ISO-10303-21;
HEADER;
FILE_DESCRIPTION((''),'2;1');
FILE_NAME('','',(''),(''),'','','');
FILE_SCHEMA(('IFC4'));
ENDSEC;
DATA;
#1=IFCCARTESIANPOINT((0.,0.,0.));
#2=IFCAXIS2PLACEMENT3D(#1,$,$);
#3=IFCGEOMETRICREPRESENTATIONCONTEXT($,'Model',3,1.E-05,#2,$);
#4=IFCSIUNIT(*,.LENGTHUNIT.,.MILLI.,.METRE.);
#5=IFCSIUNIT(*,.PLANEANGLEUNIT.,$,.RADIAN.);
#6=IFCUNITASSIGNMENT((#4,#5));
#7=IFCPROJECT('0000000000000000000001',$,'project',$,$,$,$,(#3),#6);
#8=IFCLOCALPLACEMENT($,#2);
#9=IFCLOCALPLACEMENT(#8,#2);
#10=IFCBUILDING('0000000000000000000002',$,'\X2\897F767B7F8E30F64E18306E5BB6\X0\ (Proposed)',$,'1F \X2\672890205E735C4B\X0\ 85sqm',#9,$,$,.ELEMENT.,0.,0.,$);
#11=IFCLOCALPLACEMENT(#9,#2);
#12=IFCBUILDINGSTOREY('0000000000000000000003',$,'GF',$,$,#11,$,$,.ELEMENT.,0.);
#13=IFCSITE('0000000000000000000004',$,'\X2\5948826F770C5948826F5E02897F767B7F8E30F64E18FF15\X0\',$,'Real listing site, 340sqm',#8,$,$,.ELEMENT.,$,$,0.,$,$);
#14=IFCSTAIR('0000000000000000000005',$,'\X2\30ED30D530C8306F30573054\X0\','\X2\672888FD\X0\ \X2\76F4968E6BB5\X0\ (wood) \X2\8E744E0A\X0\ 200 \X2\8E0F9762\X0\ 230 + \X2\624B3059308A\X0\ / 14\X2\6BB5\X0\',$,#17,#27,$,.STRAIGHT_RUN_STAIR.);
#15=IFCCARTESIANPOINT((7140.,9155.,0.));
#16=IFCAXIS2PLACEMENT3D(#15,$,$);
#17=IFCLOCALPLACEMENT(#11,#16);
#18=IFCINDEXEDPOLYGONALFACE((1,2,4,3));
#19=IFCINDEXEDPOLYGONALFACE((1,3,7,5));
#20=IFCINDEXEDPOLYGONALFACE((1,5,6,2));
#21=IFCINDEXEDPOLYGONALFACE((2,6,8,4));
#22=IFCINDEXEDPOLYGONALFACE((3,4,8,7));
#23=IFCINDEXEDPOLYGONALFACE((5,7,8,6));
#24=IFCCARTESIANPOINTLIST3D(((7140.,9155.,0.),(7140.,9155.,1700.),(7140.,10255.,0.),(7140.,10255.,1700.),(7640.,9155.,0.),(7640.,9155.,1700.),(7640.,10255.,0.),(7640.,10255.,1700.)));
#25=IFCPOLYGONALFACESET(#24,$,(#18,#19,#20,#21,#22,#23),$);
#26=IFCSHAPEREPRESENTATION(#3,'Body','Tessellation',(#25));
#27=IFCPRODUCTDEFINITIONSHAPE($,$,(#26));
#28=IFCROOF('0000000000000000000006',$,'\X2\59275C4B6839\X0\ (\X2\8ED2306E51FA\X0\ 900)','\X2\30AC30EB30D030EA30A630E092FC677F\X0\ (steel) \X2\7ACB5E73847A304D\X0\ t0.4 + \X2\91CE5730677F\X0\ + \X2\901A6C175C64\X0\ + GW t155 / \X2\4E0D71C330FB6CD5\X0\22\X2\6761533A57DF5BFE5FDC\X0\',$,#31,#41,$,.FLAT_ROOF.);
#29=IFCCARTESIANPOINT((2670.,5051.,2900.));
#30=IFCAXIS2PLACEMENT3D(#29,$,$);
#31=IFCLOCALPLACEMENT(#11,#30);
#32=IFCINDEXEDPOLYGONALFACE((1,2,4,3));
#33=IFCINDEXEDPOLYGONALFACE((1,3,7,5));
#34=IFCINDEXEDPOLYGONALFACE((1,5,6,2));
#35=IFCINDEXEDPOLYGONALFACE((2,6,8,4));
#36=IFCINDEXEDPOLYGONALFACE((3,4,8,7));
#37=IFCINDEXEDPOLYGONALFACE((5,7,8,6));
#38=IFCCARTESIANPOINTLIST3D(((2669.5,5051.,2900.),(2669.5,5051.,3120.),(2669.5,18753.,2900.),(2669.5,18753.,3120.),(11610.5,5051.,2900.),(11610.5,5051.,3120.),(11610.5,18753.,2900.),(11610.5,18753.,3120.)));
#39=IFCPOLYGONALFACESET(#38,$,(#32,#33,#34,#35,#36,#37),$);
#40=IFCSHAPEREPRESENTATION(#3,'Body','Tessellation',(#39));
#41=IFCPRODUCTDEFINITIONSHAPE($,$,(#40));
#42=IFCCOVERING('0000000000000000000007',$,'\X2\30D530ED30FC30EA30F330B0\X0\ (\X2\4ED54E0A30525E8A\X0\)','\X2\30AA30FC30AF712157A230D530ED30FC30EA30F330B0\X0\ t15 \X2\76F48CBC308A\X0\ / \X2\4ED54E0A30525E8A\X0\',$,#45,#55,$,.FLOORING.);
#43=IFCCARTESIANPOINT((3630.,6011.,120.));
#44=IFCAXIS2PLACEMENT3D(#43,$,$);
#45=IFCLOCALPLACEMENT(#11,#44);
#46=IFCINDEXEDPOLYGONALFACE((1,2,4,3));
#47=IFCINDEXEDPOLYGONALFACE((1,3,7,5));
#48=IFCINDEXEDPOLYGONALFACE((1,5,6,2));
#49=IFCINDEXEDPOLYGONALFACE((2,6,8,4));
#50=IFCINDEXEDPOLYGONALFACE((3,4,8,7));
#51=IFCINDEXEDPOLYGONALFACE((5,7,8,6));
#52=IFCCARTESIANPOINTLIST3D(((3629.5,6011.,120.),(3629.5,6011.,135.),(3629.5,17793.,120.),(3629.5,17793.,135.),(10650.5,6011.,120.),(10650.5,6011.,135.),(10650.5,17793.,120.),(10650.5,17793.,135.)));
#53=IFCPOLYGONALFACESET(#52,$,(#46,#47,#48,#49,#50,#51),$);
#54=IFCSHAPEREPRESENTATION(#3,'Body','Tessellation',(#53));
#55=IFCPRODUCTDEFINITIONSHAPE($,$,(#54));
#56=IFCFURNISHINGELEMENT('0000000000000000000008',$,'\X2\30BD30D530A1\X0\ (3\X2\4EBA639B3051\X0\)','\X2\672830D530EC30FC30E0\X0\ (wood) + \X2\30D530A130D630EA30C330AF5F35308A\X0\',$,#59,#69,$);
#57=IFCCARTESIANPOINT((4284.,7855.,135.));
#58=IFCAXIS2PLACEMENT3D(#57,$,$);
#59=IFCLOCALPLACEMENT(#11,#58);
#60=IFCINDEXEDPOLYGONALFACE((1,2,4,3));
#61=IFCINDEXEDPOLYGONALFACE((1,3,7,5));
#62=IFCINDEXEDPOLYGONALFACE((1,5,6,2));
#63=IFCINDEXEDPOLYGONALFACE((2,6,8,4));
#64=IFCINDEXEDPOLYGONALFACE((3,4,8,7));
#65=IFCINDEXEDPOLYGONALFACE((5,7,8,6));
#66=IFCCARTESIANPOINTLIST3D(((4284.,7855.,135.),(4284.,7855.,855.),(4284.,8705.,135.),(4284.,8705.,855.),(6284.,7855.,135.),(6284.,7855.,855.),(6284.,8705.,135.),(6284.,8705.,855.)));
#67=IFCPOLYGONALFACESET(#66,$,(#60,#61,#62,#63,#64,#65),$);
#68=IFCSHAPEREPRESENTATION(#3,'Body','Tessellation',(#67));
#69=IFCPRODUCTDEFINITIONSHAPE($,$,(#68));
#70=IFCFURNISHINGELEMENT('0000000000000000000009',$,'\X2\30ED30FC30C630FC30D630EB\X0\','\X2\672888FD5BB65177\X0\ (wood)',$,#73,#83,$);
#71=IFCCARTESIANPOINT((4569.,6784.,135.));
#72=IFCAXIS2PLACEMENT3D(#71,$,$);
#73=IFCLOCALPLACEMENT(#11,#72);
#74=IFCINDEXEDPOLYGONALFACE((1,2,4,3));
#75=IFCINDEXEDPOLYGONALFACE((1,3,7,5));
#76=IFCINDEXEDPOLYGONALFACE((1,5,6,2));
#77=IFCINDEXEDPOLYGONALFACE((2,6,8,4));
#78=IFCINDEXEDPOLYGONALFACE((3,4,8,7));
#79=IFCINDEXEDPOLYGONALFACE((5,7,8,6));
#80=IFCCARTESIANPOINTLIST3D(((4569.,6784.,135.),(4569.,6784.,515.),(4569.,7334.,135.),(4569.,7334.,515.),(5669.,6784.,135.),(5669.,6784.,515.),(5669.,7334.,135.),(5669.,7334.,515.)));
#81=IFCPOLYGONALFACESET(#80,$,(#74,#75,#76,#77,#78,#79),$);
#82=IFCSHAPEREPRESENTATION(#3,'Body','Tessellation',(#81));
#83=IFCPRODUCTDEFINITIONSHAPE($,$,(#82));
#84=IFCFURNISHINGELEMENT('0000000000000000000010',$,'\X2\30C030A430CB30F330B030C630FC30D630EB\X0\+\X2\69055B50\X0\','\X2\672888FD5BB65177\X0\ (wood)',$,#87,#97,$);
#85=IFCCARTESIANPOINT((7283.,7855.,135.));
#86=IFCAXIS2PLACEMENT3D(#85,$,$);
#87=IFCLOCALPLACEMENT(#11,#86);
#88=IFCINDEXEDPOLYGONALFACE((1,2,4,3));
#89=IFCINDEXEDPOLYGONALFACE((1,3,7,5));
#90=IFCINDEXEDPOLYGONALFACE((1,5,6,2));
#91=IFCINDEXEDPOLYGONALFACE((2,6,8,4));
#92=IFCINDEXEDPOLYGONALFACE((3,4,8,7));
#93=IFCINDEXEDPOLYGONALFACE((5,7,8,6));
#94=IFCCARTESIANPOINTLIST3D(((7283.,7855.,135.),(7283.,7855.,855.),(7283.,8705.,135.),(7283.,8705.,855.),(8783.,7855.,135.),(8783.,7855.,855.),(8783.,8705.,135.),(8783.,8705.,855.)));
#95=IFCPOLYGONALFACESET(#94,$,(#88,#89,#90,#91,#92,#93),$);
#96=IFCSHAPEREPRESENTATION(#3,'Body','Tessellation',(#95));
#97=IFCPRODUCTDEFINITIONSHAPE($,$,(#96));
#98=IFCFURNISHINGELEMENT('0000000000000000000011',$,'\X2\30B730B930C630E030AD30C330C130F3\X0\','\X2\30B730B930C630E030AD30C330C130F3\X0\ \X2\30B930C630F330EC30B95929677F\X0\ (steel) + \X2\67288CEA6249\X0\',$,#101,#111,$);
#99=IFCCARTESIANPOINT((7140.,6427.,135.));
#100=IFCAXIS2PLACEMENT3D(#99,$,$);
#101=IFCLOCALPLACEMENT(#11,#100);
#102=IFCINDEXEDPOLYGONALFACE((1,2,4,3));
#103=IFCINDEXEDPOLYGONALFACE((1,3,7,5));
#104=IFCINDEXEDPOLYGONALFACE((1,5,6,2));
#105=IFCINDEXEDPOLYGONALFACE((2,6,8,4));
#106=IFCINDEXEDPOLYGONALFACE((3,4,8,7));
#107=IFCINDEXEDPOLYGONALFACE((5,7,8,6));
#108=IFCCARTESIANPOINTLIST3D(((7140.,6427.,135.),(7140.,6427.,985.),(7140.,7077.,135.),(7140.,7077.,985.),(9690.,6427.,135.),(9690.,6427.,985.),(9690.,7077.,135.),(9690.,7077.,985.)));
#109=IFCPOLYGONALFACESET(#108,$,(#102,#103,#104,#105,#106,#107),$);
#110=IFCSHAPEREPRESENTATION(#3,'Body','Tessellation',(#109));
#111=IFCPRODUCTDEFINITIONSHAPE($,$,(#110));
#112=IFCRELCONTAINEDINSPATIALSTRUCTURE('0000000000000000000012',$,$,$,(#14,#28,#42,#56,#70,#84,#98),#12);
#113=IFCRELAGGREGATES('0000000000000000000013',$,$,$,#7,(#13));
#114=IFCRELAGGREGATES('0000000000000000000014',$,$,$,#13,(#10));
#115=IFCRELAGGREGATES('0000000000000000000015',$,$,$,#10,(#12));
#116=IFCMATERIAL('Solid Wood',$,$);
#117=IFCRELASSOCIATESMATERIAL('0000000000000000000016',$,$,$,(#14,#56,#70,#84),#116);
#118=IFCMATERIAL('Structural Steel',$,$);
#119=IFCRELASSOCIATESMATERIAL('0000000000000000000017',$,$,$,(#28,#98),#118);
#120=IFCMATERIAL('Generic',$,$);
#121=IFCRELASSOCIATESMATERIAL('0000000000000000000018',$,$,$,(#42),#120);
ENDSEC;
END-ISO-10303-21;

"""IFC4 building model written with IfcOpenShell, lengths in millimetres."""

from ifc_helpers import new_model, si_unit, frame, frame_2d, origin, place, context, project, spatial, rectangle, extrude, material, element, save


model = new_model("IFC4")

# Units and contexts
model_context = context("Model", 3, precision=1e-05, world=origin())
ifc_project = project(units=[si_unit("LENGTHUNIT", "METRE", prefix="MILLI"), si_unit("PLANEANGLEUNIT", "RADIAN")], contexts=[model_context])

# Site, building, storey
site_placement = place(None, origin())
site = spatial("IfcSite", under=ifc_project, at=site_placement, Name="奈良県奈良市西登美ヶ丘５", ObjectType="Real listing site, 340sqm", CompositionType="ELEMENT", RefElevation=0.0)
building_placement = place(site_placement, origin())
building = spatial("IfcBuilding", under=site, at=building_placement, Name="西登美ヶ丘の家 (Proposed)", ObjectType="1F 木造平屋 85sqm", CompositionType="ELEMENT", ElevationOfRefHeight=0.0, ElevationOfTerrain=0.0)
storey_placement = place(building_placement, origin())
storey = spatial("IfcBuildingStorey", under=building, at=storey_placement, Name="GF", CompositionType="ELEMENT", Elevation=0.0)

# Shared definitions
ifc_material_1 = material(Name="Solid Wood")

# Stair
stair_placement = place(storey_placement, frame((7140.0, 9155.0, 0.0)))
element("IfcStair", 1, at=stair_placement, inside=storey, material=ifc_material_1, Name="ロフトはしご", Description="木製 直階段 (wood) 蹴上 200 踏面 230 + 手すり / 14段", PredefinedType="STRAIGHT_RUN_STAIR", context=model_context, shape_type="SweptSolid", body=[
    extrude(rectangle(XDim=500.0, YDim=1100.0, at=frame_2d((250.0, 550.0))), frame((7140.0, 9155.0, 0.0)), (0.0, 0.0, 1.0), 1700.0),
])

# Roof
ifc_material_2 = material(Name="Structural Steel")
roof_placement = place(storey_placement, frame((2670.0, 5051.0, 2900.0)))
element("IfcRoof", 2, at=roof_placement, inside=storey, material=ifc_material_2, Name="大屋根 (軒の出 900)", Description="ガルバリウム鋼板 (steel) 立平葺き t0.4 + 野地板 + 通気層 + GW t155 / 不燃・法22条区域対応", PredefinedType="FLAT_ROOF", context=model_context, shape_type="SweptSolid", body=[
    extrude(rectangle(XDim=8941.0, YDim=13702.0, at=frame_2d((4470.0, 6851.0))), frame((2670.0, 5051.0, 2900.0)), (0.0, 0.0, 1.0), 220.0),
])

# Covering
ifc_material_3 = material(Name="Generic")
covering_placement = place(storey_placement, frame((3630.0, 6011.0, 120.0)))
element("IfcCovering", 3, at=covering_placement, inside=storey, material=ifc_material_3, Name="フローリング (仕上げ床)", Description="オーク無垢フローリング t15 直貼り / 仕上げ床", PredefinedType="FLOORING", context=model_context, shape_type="SweptSolid", body=[
    extrude(rectangle(XDim=7021.0, YDim=11782.0, at=frame_2d((3510.0, 5891.0))), frame((3630.0, 6011.0, 120.0)), (0.0, 0.0, 1.0), 15.0),
])

# Furnishing elements
furnishing_1_placement = place(storey_placement, frame((4284.0, 7855.0, 135.0)))
element("IfcFurnishingElement", 4, at=furnishing_1_placement, inside=storey, material=ifc_material_1, Name="ソファ (3人掛け)", Description="木フレーム (wood) + ファブリック張り", context=model_context, shape_type="SweptSolid", body=[
    extrude(rectangle(XDim=2000.0, YDim=850.0, at=frame_2d((1000.0, 425.0))), frame((4284.0, 7855.0, 135.0)), (0.0, 0.0, 1.0), 720.0),
])
furnishing_2_placement = place(storey_placement, frame((4569.0, 6784.0, 135.0)))
element("IfcFurnishingElement", 5, at=furnishing_2_placement, inside=storey, material=ifc_material_1, Name="ローテーブル", Description="木製家具 (wood)", context=model_context, shape_type="SweptSolid", body=[
    extrude(rectangle(XDim=1100.0, YDim=550.0, at=frame_2d((550.0, 275.0))), frame((4569.0, 6784.0, 135.0)), (0.0, 0.0, 1.0), 380.0),
])
furnishing_3_placement = place(storey_placement, frame((7283.0, 7855.0, 135.0)))
element("IfcFurnishingElement", 6, at=furnishing_3_placement, inside=storey, material=ifc_material_1, Name="ダイニングテーブル+椅子", Description="木製家具 (wood)", context=model_context, shape_type="SweptSolid", body=[
    extrude(rectangle(XDim=1500.0, YDim=850.0, at=frame_2d((750.0, 425.0))), frame((7283.0, 7855.0, 135.0)), (0.0, 0.0, 1.0), 720.0),
])
furnishing_4_placement = place(storey_placement, frame((7140.0, 6427.0, 135.0)))
element("IfcFurnishingElement", 7, at=furnishing_4_placement, inside=storey, material=ifc_material_2, Name="システムキッチン", Description="システムキッチン ステンレス天板 (steel) + 木質扉", context=model_context, shape_type="SweptSolid", body=[
    extrude(rectangle(XDim=2550.0, YDim=650.0, at=frame_2d((1275.0, 325.0))), frame((7140.0, 6427.0, 135.0)), (0.0, 0.0, 1.0), 850.0),
])

save(model, "model.ifc")
